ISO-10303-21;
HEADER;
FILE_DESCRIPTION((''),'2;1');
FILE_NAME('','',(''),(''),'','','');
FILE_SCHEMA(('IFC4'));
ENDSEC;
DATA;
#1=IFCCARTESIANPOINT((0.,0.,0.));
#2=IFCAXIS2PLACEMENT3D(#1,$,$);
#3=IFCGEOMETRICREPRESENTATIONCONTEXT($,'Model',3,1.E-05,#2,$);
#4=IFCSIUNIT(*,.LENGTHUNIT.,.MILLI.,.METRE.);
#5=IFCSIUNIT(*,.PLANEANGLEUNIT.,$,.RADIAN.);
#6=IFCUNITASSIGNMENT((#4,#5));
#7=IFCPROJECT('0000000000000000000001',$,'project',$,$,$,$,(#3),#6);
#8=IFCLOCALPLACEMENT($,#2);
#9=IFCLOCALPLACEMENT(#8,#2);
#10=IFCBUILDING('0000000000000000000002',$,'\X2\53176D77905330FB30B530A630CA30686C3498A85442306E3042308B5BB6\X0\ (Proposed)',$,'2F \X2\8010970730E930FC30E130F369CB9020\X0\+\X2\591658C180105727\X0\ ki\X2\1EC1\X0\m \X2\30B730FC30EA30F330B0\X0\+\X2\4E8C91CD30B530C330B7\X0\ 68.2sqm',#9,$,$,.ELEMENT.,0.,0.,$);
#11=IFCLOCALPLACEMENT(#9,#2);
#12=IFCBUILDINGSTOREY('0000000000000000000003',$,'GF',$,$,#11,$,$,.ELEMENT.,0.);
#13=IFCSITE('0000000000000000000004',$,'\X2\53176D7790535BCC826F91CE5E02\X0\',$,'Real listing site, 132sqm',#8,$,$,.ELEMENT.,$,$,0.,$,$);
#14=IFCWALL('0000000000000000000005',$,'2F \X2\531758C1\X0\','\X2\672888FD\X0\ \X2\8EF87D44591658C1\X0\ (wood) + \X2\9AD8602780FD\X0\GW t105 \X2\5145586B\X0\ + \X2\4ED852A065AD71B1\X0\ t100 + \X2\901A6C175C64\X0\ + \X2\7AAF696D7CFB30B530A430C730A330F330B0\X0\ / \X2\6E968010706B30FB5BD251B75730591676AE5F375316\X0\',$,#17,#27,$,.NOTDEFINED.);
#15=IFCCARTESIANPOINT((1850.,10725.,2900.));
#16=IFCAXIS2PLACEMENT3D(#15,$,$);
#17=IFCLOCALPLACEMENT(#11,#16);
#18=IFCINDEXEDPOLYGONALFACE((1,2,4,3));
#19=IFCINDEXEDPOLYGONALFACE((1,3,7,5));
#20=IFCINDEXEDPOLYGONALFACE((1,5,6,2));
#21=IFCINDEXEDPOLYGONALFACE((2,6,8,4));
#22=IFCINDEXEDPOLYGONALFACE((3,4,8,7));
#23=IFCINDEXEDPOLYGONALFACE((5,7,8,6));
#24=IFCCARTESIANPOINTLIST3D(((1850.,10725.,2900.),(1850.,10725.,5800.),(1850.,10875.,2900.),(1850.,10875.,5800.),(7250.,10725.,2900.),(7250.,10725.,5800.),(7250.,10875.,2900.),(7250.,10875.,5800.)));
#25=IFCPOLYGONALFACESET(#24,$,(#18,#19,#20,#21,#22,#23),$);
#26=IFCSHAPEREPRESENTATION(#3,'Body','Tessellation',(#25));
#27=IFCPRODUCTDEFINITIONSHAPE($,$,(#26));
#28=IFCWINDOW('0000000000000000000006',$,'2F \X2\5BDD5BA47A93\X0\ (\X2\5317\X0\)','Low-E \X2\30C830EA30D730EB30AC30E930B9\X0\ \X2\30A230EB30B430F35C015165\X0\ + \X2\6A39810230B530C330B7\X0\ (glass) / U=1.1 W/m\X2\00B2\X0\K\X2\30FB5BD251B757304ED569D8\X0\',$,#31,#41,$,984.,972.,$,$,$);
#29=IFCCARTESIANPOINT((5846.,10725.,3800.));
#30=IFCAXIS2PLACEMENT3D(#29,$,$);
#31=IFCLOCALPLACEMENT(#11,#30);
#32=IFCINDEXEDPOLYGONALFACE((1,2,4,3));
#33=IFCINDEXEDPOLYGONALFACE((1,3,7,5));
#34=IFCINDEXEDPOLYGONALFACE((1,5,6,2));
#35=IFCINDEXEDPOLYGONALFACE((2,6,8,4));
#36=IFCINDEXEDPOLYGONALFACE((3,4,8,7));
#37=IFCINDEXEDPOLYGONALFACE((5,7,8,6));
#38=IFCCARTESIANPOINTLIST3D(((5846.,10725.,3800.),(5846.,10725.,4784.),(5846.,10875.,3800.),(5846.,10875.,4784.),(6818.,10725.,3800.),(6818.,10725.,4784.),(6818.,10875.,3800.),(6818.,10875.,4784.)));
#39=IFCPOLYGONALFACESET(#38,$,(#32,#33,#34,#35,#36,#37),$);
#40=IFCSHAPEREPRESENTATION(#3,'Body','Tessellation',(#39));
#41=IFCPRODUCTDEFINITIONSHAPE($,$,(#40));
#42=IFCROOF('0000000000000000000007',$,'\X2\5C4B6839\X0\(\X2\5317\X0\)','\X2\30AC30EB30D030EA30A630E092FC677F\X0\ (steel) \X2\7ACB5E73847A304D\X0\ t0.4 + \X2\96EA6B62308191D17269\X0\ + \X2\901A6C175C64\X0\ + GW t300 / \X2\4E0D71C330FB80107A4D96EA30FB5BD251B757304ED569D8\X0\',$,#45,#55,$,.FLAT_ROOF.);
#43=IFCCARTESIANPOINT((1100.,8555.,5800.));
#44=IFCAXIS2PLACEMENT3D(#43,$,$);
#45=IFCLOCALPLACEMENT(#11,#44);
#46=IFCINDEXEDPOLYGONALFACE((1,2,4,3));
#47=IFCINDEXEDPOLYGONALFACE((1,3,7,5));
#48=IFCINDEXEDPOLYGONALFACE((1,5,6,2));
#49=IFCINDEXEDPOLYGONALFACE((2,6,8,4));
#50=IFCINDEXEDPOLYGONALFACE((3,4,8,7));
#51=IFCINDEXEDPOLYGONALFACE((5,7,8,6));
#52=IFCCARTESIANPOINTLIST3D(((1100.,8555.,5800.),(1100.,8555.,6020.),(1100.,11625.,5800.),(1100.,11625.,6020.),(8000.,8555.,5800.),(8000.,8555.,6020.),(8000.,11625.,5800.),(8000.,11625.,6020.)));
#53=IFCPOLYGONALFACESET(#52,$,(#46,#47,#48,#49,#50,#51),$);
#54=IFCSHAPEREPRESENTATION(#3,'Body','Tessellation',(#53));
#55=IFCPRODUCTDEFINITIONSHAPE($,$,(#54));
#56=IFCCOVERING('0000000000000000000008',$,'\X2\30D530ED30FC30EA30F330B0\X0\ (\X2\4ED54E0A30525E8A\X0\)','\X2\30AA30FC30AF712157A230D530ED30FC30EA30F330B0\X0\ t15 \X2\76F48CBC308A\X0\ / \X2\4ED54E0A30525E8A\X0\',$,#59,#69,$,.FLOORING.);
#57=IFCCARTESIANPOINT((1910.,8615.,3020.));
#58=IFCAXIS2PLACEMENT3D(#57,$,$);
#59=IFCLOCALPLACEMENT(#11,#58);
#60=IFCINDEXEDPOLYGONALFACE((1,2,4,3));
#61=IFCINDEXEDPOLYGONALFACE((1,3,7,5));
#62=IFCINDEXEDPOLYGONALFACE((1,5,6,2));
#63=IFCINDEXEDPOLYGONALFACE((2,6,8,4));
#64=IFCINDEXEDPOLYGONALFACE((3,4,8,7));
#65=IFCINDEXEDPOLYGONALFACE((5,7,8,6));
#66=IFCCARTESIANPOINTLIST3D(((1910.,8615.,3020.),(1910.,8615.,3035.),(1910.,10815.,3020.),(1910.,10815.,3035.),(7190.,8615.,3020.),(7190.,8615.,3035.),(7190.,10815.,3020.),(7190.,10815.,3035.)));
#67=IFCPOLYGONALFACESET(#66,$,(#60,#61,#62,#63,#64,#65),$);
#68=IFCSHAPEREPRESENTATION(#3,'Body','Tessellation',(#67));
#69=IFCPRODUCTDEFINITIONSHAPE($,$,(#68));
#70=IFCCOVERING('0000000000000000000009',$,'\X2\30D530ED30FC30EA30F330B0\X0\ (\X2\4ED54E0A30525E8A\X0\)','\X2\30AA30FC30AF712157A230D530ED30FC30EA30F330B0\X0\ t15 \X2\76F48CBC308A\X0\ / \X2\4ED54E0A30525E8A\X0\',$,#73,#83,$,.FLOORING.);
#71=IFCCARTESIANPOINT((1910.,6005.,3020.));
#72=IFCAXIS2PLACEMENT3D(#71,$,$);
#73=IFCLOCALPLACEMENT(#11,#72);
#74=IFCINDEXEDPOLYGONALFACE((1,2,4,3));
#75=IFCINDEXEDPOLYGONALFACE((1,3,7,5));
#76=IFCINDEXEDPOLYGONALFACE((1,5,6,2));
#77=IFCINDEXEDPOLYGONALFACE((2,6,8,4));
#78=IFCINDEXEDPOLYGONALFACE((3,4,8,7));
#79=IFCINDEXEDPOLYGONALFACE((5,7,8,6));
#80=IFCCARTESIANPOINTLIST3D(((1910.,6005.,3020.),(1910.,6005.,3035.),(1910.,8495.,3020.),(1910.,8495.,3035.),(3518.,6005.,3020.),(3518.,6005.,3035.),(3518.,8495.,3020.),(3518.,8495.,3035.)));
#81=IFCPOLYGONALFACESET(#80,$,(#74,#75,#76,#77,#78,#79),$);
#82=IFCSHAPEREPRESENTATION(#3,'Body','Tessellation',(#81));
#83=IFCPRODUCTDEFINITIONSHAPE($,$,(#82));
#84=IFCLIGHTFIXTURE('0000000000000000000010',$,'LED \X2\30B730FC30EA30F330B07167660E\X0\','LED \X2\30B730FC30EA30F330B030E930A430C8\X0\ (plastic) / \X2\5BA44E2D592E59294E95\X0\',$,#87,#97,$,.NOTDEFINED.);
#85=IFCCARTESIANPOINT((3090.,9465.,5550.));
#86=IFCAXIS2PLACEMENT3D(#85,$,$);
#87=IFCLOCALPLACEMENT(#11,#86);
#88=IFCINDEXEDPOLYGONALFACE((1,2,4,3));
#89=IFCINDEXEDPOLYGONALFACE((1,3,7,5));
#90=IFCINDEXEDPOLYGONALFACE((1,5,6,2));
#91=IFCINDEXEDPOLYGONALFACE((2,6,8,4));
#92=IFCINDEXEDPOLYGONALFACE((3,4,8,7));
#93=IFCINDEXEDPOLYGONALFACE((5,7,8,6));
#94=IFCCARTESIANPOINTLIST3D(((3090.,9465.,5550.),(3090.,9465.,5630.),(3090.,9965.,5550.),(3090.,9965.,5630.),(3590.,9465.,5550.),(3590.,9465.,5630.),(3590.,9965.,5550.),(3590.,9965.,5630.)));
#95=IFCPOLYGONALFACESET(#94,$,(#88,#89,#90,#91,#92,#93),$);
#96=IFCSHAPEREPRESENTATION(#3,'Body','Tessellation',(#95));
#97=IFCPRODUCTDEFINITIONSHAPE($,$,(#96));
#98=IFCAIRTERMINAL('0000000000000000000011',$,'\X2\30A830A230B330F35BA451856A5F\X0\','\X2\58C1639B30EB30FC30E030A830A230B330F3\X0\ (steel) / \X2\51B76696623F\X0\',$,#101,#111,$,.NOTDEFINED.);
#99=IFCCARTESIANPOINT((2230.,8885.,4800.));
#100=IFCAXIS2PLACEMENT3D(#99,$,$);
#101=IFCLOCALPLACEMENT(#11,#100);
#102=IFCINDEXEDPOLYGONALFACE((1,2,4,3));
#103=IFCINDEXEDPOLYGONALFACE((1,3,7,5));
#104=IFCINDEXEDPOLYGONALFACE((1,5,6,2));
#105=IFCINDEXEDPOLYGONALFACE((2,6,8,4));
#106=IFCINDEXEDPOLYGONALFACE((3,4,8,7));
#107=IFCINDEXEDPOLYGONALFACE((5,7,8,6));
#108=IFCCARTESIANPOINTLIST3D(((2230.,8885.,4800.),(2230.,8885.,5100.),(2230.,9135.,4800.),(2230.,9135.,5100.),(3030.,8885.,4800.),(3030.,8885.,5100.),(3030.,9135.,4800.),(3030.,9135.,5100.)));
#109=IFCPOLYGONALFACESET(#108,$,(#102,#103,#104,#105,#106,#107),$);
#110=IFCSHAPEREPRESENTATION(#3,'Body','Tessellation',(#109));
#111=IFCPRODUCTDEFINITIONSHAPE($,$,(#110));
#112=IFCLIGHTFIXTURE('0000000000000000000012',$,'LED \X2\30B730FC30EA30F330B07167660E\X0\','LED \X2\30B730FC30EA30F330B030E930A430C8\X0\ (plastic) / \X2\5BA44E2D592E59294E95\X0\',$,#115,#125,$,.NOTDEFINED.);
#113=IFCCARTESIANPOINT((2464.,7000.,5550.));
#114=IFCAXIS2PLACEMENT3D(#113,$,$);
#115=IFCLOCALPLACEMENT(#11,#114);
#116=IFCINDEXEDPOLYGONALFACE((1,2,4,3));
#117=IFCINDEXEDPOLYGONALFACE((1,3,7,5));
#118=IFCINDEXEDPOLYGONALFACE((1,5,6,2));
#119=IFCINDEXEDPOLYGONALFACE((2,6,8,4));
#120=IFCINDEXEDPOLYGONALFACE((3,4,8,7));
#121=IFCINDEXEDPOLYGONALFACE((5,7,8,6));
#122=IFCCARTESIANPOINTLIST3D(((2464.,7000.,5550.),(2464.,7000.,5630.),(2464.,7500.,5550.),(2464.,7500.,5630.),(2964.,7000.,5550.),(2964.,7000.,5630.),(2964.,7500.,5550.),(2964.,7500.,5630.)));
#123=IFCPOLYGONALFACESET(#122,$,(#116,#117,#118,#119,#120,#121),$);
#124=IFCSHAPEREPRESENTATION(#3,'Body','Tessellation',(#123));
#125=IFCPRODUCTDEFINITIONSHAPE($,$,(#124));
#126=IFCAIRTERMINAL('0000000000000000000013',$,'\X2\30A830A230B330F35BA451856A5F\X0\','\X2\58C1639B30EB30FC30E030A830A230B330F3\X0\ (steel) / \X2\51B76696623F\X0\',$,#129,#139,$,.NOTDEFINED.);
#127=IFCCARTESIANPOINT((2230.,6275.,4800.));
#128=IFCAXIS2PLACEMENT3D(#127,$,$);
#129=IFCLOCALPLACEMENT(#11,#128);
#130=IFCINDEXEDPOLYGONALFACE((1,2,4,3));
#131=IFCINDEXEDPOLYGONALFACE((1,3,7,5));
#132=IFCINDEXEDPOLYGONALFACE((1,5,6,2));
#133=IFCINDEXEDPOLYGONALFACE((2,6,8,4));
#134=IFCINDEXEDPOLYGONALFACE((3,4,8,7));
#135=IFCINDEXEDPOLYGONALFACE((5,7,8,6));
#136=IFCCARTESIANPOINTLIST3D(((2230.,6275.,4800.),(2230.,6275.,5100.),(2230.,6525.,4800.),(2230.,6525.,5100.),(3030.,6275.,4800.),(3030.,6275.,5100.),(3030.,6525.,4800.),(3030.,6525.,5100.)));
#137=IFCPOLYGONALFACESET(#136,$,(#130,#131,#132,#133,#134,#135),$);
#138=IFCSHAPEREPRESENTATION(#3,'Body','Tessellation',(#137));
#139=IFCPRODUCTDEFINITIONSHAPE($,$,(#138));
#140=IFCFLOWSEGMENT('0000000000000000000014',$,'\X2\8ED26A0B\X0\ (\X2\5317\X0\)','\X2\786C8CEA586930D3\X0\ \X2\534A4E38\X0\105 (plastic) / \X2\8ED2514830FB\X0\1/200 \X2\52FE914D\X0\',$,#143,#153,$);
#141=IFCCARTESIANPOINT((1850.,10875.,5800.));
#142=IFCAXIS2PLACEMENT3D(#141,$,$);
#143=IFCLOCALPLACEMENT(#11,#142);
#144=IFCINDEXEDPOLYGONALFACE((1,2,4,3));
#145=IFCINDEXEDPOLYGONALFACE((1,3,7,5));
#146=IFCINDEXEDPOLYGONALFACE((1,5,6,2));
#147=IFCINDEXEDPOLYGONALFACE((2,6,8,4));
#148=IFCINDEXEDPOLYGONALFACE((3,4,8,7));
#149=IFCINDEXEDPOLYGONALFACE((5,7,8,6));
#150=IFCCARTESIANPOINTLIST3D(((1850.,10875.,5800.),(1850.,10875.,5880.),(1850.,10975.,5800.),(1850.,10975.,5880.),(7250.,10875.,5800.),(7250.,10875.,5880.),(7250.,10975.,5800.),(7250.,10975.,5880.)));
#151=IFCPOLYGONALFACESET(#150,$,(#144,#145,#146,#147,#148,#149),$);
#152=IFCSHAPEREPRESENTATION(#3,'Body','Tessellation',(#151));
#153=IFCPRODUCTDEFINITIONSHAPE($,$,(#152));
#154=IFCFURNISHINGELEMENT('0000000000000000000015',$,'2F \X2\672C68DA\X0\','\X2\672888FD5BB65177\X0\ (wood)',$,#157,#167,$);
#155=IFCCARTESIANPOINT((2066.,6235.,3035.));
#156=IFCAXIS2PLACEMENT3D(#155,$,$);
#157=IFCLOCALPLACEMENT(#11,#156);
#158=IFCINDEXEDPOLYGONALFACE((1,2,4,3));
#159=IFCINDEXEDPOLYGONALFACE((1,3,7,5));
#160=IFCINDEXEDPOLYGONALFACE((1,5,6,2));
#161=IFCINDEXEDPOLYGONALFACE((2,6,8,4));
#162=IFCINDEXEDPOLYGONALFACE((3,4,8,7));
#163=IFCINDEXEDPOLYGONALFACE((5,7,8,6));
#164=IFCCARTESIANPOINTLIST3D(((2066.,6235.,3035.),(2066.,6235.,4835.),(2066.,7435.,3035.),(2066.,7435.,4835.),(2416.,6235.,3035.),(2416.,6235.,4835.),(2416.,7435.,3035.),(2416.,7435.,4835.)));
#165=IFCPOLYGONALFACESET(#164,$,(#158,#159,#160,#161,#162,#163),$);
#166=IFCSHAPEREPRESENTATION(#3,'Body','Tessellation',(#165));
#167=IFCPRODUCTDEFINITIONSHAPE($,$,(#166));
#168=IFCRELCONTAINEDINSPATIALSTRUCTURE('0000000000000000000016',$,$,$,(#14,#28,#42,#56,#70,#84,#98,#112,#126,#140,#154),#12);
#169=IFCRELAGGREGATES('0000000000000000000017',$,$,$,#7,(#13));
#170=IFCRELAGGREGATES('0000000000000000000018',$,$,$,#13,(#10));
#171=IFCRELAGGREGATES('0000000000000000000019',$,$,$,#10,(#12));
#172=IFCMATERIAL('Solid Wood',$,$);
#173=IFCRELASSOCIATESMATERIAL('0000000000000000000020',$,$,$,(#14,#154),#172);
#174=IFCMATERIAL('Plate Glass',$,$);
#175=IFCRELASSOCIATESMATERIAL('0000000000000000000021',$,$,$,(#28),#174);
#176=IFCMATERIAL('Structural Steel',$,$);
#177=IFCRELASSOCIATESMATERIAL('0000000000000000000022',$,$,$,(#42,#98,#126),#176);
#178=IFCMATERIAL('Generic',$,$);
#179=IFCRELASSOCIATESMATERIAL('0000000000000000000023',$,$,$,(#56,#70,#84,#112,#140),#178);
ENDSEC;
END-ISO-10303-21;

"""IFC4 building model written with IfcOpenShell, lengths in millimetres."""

from ifc_helpers import new_model, si_unit, frame, frame_2d, origin, place, context, project, spatial, rectangle, extrude, material, element, fill, save


model = new_model("IFC4")

# Units and contexts
model_context = context("Model", 3, precision=1e-05, world=origin())
ifc_project = project(units=[si_unit("LENGTHUNIT", "METRE", prefix="MILLI"), si_unit("PLANEANGLEUNIT", "RADIAN")], contexts=[model_context])

# Site, building, storey
site_placement = place(None, origin())
site = spatial("IfcSite", under=ifc_project, at=site_placement, Name="北海道富良野市", ObjectType="Real listing site, 132sqm", CompositionType="ELEMENT", RefElevation=0.0)
building_placement = place(site_placement, origin())
building = spatial("IfcBuilding", under=site, at=building_placement, Name="北海道・サウナと水風呂のある家 (Proposed)", ObjectType="2F 耐震ラーメン構造+外壁耐圧 kiềm シーリング+二重サッシ 68.2sqm", CompositionType="ELEMENT", ElevationOfRefHeight=0.0, ElevationOfTerrain=0.0)
storey_placement = place(building_placement, origin())
storey = spatial("IfcBuildingStorey", under=building, at=storey_placement, Name="GF", CompositionType="ELEMENT", Elevation=0.0)

# Shared definitions
ifc_material_1 = material(Name="Solid Wood")

# Wall, opening, window
wall_placement = place(storey_placement, frame((1850.0, 10725.0, 2900.0)))
wall = element("IfcWall", 1, at=wall_placement, inside=storey, material=ifc_material_1, Name="2F 北壁", Description="木製 軸組外壁 (wood) + 高性能GW t105 充填 + 付加断熱 t100 + 通気層 + 窯業系サイディング / 準耐火・寒冷地外皮強化", PredefinedType="NOTDEFINED", context=model_context, shape_type="SweptSolid", body=[
    extrude(rectangle(XDim=5400.0, YDim=150.0, at=frame_2d((2700.0, 75.0))), frame((1850.0, 10725.0, 2900.0)), (0.0, 0.0, 1.0), 2900.0),
])
opening_placement = place(storey_placement, frame((5846.0, 10725.0, 3800.0)))
opening = element("IfcOpeningElement", 2, at=opening_placement, cuts=wall, PredefinedType="NOTDEFINED", context=model_context, shape_type="SweptSolid", body=[
    extrude(rectangle(XDim=972.0, YDim=150.0, at=frame_2d((486.0, 75.0))), frame((5846.0, 10725.0, 3800.0)), (0.0, 0.0, 1.0), 984.0),
])
ifc_material_2 = material(Name="Plate Glass")
window_placement = place(storey_placement, frame((5846.0, 10725.0, 3800.0)))
window = element("IfcWindow", 3, at=window_placement, inside=storey, material=ifc_material_2, Name="2F 寝室窓 (北)", Description="Low-E トリプルガラス アルゴン封入 + 樹脂サッシ (glass) / U=1.1 W/m²K・寒冷地仕様", OverallHeight=984.0, OverallWidth=972.0, context=model_context, shape_type="SweptSolid", body=[
    extrude(rectangle(XDim=972.0, YDim=150.0, at=frame_2d((486.0, 75.0))), frame((5846.0, 10725.0, 3800.0)), (0.0, 0.0, 1.0), 984.0),
])
fill(opening, window)

# Roof
ifc_material_3 = material(Name="Structural Steel")
for number, where, name in (
    (4, (1100.0, 8555.0, 5800.0), "屋根(北)"),
):
    element("IfcRoof", number, at=place(storey_placement, frame(where)), inside=storey, material=ifc_material_3, Name=name, Description="ガルバリウム鋼板 (steel) 立平葺き t0.4 + 雪止め金物 + 通気層 + GW t300 / 不燃・耐積雪・寒冷地仕様", PredefinedType="FLAT_ROOF", context=model_context, shape_type="SweptSolid", body=[
        extrude(rectangle(XDim=6900.0, YDim=3070.0, at=frame_2d((3450.0, 1535.0))), frame((1100.0, 8555.0, 5800.0)), (0.0, 0.0, 1.0), 220.0),
    ])

# Coverings
ifc_material_4 = material(Name="Generic")
covering_1_placement = place(storey_placement, frame((1910.0, 8615.0, 3020.0)))
element("IfcCovering", 5, at=covering_1_placement, inside=storey, material=ifc_material_4, Name="フローリング (仕上げ床)", Description="オーク無垢フローリング t15 直貼り / 仕上げ床", PredefinedType="FLOORING", context=model_context, shape_type="SweptSolid", body=[
    extrude(rectangle(XDim=5280.0, YDim=2200.0, at=frame_2d((2640.0, 1100.0))), frame((1910.0, 8615.0, 3020.0)), (0.0, 0.0, 1.0), 15.0),
])
covering_2_placement = place(storey_placement, frame((1910.0, 6005.0, 3020.0)))
element("IfcCovering", 6, at=covering_2_placement, inside=storey, material=ifc_material_4, Name="フローリング (仕上げ床)", Description="オーク無垢フローリング t15 直貼り / 仕上げ床", PredefinedType="FLOORING", context=model_context, shape_type="SweptSolid", body=[
    extrude(rectangle(XDim=1608.0, YDim=2490.0, at=frame_2d((804.0, 1245.0))), frame((1910.0, 6005.0, 3020.0)), (0.0, 0.0, 1.0), 15.0),
])

# Light fixture
light_fixture_1_placement = place(storey_placement, frame((3090.0, 9465.0, 5550.0)))
element("IfcLightFixture", 7, at=light_fixture_1_placement, inside=storey, material=ifc_material_4, Name="LED シーリング照明", Description="LED シーリングライト (plastic) / 室中央天井", PredefinedType="NOTDEFINED", context=model_context, shape_type="SweptSolid", body=[
    extrude(rectangle(XDim=500.0, YDim=500.0, at=frame_2d((250.0, 250.0))), frame((3090.0, 9465.0, 5550.0)), (0.0, 0.0, 1.0), 80.0),
])

# Air terminal
air_terminal_1_placement = place(storey_placement, frame((2230.0, 8885.0, 4800.0)))
element("IfcAirTerminal", 8, at=air_terminal_1_placement, inside=storey, material=ifc_material_3, Name="エアコン室内機", Description="壁掛ルームエアコン (steel) / 冷暖房", PredefinedType="NOTDEFINED", context=model_context, shape_type="SweptSolid", body=[
    extrude(rectangle(XDim=800.0, YDim=250.0, at=frame_2d((400.0, 125.0))), frame((2230.0, 8885.0, 4800.0)), (0.0, 0.0, 1.0), 300.0),
])

# Light fixture
light_fixture_2_placement = place(storey_placement, frame((2464.0, 7000.0, 5550.0)))
element("IfcLightFixture", 9, at=light_fixture_2_placement, inside=storey, material=ifc_material_4, Name="LED シーリング照明", Description="LED シーリングライト (plastic) / 室中央天井", PredefinedType="NOTDEFINED", context=model_context, shape_type="SweptSolid", body=[
    extrude(rectangle(XDim=500.0, YDim=500.0, at=frame_2d((250.0, 250.0))), frame((2464.0, 7000.0, 5550.0)), (0.0, 0.0, 1.0), 80.0),
])

# Air terminal
air_terminal_2_placement = place(storey_placement, frame((2230.0, 6275.0, 4800.0)))
element("IfcAirTerminal", 10, at=air_terminal_2_placement, inside=storey, material=ifc_material_3, Name="エアコン室内機", Description="壁掛ルームエアコン (steel) / 冷暖房", PredefinedType="NOTDEFINED", context=model_context, shape_type="SweptSolid", body=[
    extrude(rectangle(XDim=800.0, YDim=250.0, at=frame_2d((400.0, 125.0))), frame((2230.0, 6275.0, 4800.0)), (0.0, 0.0, 1.0), 300.0),
])

# Flow segment
flow_segment_placement = place(storey_placement, frame((1850.0, 10875.0, 5800.0)))
element("IfcFlowSegment", 11, at=flow_segment_placement, inside=storey, material=ifc_material_4, Name="軒樋 (北)", Description="硬質塩ビ 半丸105 (plastic) / 軒先・1/200 勾配", context=model_context, shape_type="SweptSolid", body=[
    extrude(rectangle(XDim=5400.0, YDim=100.0, at=frame_2d((2700.0, 50.0))), frame((1850.0, 10875.0, 5800.0)), (0.0, 0.0, 1.0), 80.0),
])

# Furnishing element
furnishing_placement = place(storey_placement, frame((2066.0, 6235.0, 3035.0)))
element("IfcFurnishingElement", 12, at=furnishing_placement, inside=storey, material=ifc_material_1, Name="2F 本棚", Description="木製家具 (wood)", context=model_context, shape_type="SweptSolid", body=[
    extrude(rectangle(XDim=350.0, YDim=1200.0, at=frame_2d((175.0, 600.0))), frame((2066.0, 6235.0, 3035.0)), (0.0, 0.0, 1.0), 1800.0),
])

save(model, "model.ifc")
